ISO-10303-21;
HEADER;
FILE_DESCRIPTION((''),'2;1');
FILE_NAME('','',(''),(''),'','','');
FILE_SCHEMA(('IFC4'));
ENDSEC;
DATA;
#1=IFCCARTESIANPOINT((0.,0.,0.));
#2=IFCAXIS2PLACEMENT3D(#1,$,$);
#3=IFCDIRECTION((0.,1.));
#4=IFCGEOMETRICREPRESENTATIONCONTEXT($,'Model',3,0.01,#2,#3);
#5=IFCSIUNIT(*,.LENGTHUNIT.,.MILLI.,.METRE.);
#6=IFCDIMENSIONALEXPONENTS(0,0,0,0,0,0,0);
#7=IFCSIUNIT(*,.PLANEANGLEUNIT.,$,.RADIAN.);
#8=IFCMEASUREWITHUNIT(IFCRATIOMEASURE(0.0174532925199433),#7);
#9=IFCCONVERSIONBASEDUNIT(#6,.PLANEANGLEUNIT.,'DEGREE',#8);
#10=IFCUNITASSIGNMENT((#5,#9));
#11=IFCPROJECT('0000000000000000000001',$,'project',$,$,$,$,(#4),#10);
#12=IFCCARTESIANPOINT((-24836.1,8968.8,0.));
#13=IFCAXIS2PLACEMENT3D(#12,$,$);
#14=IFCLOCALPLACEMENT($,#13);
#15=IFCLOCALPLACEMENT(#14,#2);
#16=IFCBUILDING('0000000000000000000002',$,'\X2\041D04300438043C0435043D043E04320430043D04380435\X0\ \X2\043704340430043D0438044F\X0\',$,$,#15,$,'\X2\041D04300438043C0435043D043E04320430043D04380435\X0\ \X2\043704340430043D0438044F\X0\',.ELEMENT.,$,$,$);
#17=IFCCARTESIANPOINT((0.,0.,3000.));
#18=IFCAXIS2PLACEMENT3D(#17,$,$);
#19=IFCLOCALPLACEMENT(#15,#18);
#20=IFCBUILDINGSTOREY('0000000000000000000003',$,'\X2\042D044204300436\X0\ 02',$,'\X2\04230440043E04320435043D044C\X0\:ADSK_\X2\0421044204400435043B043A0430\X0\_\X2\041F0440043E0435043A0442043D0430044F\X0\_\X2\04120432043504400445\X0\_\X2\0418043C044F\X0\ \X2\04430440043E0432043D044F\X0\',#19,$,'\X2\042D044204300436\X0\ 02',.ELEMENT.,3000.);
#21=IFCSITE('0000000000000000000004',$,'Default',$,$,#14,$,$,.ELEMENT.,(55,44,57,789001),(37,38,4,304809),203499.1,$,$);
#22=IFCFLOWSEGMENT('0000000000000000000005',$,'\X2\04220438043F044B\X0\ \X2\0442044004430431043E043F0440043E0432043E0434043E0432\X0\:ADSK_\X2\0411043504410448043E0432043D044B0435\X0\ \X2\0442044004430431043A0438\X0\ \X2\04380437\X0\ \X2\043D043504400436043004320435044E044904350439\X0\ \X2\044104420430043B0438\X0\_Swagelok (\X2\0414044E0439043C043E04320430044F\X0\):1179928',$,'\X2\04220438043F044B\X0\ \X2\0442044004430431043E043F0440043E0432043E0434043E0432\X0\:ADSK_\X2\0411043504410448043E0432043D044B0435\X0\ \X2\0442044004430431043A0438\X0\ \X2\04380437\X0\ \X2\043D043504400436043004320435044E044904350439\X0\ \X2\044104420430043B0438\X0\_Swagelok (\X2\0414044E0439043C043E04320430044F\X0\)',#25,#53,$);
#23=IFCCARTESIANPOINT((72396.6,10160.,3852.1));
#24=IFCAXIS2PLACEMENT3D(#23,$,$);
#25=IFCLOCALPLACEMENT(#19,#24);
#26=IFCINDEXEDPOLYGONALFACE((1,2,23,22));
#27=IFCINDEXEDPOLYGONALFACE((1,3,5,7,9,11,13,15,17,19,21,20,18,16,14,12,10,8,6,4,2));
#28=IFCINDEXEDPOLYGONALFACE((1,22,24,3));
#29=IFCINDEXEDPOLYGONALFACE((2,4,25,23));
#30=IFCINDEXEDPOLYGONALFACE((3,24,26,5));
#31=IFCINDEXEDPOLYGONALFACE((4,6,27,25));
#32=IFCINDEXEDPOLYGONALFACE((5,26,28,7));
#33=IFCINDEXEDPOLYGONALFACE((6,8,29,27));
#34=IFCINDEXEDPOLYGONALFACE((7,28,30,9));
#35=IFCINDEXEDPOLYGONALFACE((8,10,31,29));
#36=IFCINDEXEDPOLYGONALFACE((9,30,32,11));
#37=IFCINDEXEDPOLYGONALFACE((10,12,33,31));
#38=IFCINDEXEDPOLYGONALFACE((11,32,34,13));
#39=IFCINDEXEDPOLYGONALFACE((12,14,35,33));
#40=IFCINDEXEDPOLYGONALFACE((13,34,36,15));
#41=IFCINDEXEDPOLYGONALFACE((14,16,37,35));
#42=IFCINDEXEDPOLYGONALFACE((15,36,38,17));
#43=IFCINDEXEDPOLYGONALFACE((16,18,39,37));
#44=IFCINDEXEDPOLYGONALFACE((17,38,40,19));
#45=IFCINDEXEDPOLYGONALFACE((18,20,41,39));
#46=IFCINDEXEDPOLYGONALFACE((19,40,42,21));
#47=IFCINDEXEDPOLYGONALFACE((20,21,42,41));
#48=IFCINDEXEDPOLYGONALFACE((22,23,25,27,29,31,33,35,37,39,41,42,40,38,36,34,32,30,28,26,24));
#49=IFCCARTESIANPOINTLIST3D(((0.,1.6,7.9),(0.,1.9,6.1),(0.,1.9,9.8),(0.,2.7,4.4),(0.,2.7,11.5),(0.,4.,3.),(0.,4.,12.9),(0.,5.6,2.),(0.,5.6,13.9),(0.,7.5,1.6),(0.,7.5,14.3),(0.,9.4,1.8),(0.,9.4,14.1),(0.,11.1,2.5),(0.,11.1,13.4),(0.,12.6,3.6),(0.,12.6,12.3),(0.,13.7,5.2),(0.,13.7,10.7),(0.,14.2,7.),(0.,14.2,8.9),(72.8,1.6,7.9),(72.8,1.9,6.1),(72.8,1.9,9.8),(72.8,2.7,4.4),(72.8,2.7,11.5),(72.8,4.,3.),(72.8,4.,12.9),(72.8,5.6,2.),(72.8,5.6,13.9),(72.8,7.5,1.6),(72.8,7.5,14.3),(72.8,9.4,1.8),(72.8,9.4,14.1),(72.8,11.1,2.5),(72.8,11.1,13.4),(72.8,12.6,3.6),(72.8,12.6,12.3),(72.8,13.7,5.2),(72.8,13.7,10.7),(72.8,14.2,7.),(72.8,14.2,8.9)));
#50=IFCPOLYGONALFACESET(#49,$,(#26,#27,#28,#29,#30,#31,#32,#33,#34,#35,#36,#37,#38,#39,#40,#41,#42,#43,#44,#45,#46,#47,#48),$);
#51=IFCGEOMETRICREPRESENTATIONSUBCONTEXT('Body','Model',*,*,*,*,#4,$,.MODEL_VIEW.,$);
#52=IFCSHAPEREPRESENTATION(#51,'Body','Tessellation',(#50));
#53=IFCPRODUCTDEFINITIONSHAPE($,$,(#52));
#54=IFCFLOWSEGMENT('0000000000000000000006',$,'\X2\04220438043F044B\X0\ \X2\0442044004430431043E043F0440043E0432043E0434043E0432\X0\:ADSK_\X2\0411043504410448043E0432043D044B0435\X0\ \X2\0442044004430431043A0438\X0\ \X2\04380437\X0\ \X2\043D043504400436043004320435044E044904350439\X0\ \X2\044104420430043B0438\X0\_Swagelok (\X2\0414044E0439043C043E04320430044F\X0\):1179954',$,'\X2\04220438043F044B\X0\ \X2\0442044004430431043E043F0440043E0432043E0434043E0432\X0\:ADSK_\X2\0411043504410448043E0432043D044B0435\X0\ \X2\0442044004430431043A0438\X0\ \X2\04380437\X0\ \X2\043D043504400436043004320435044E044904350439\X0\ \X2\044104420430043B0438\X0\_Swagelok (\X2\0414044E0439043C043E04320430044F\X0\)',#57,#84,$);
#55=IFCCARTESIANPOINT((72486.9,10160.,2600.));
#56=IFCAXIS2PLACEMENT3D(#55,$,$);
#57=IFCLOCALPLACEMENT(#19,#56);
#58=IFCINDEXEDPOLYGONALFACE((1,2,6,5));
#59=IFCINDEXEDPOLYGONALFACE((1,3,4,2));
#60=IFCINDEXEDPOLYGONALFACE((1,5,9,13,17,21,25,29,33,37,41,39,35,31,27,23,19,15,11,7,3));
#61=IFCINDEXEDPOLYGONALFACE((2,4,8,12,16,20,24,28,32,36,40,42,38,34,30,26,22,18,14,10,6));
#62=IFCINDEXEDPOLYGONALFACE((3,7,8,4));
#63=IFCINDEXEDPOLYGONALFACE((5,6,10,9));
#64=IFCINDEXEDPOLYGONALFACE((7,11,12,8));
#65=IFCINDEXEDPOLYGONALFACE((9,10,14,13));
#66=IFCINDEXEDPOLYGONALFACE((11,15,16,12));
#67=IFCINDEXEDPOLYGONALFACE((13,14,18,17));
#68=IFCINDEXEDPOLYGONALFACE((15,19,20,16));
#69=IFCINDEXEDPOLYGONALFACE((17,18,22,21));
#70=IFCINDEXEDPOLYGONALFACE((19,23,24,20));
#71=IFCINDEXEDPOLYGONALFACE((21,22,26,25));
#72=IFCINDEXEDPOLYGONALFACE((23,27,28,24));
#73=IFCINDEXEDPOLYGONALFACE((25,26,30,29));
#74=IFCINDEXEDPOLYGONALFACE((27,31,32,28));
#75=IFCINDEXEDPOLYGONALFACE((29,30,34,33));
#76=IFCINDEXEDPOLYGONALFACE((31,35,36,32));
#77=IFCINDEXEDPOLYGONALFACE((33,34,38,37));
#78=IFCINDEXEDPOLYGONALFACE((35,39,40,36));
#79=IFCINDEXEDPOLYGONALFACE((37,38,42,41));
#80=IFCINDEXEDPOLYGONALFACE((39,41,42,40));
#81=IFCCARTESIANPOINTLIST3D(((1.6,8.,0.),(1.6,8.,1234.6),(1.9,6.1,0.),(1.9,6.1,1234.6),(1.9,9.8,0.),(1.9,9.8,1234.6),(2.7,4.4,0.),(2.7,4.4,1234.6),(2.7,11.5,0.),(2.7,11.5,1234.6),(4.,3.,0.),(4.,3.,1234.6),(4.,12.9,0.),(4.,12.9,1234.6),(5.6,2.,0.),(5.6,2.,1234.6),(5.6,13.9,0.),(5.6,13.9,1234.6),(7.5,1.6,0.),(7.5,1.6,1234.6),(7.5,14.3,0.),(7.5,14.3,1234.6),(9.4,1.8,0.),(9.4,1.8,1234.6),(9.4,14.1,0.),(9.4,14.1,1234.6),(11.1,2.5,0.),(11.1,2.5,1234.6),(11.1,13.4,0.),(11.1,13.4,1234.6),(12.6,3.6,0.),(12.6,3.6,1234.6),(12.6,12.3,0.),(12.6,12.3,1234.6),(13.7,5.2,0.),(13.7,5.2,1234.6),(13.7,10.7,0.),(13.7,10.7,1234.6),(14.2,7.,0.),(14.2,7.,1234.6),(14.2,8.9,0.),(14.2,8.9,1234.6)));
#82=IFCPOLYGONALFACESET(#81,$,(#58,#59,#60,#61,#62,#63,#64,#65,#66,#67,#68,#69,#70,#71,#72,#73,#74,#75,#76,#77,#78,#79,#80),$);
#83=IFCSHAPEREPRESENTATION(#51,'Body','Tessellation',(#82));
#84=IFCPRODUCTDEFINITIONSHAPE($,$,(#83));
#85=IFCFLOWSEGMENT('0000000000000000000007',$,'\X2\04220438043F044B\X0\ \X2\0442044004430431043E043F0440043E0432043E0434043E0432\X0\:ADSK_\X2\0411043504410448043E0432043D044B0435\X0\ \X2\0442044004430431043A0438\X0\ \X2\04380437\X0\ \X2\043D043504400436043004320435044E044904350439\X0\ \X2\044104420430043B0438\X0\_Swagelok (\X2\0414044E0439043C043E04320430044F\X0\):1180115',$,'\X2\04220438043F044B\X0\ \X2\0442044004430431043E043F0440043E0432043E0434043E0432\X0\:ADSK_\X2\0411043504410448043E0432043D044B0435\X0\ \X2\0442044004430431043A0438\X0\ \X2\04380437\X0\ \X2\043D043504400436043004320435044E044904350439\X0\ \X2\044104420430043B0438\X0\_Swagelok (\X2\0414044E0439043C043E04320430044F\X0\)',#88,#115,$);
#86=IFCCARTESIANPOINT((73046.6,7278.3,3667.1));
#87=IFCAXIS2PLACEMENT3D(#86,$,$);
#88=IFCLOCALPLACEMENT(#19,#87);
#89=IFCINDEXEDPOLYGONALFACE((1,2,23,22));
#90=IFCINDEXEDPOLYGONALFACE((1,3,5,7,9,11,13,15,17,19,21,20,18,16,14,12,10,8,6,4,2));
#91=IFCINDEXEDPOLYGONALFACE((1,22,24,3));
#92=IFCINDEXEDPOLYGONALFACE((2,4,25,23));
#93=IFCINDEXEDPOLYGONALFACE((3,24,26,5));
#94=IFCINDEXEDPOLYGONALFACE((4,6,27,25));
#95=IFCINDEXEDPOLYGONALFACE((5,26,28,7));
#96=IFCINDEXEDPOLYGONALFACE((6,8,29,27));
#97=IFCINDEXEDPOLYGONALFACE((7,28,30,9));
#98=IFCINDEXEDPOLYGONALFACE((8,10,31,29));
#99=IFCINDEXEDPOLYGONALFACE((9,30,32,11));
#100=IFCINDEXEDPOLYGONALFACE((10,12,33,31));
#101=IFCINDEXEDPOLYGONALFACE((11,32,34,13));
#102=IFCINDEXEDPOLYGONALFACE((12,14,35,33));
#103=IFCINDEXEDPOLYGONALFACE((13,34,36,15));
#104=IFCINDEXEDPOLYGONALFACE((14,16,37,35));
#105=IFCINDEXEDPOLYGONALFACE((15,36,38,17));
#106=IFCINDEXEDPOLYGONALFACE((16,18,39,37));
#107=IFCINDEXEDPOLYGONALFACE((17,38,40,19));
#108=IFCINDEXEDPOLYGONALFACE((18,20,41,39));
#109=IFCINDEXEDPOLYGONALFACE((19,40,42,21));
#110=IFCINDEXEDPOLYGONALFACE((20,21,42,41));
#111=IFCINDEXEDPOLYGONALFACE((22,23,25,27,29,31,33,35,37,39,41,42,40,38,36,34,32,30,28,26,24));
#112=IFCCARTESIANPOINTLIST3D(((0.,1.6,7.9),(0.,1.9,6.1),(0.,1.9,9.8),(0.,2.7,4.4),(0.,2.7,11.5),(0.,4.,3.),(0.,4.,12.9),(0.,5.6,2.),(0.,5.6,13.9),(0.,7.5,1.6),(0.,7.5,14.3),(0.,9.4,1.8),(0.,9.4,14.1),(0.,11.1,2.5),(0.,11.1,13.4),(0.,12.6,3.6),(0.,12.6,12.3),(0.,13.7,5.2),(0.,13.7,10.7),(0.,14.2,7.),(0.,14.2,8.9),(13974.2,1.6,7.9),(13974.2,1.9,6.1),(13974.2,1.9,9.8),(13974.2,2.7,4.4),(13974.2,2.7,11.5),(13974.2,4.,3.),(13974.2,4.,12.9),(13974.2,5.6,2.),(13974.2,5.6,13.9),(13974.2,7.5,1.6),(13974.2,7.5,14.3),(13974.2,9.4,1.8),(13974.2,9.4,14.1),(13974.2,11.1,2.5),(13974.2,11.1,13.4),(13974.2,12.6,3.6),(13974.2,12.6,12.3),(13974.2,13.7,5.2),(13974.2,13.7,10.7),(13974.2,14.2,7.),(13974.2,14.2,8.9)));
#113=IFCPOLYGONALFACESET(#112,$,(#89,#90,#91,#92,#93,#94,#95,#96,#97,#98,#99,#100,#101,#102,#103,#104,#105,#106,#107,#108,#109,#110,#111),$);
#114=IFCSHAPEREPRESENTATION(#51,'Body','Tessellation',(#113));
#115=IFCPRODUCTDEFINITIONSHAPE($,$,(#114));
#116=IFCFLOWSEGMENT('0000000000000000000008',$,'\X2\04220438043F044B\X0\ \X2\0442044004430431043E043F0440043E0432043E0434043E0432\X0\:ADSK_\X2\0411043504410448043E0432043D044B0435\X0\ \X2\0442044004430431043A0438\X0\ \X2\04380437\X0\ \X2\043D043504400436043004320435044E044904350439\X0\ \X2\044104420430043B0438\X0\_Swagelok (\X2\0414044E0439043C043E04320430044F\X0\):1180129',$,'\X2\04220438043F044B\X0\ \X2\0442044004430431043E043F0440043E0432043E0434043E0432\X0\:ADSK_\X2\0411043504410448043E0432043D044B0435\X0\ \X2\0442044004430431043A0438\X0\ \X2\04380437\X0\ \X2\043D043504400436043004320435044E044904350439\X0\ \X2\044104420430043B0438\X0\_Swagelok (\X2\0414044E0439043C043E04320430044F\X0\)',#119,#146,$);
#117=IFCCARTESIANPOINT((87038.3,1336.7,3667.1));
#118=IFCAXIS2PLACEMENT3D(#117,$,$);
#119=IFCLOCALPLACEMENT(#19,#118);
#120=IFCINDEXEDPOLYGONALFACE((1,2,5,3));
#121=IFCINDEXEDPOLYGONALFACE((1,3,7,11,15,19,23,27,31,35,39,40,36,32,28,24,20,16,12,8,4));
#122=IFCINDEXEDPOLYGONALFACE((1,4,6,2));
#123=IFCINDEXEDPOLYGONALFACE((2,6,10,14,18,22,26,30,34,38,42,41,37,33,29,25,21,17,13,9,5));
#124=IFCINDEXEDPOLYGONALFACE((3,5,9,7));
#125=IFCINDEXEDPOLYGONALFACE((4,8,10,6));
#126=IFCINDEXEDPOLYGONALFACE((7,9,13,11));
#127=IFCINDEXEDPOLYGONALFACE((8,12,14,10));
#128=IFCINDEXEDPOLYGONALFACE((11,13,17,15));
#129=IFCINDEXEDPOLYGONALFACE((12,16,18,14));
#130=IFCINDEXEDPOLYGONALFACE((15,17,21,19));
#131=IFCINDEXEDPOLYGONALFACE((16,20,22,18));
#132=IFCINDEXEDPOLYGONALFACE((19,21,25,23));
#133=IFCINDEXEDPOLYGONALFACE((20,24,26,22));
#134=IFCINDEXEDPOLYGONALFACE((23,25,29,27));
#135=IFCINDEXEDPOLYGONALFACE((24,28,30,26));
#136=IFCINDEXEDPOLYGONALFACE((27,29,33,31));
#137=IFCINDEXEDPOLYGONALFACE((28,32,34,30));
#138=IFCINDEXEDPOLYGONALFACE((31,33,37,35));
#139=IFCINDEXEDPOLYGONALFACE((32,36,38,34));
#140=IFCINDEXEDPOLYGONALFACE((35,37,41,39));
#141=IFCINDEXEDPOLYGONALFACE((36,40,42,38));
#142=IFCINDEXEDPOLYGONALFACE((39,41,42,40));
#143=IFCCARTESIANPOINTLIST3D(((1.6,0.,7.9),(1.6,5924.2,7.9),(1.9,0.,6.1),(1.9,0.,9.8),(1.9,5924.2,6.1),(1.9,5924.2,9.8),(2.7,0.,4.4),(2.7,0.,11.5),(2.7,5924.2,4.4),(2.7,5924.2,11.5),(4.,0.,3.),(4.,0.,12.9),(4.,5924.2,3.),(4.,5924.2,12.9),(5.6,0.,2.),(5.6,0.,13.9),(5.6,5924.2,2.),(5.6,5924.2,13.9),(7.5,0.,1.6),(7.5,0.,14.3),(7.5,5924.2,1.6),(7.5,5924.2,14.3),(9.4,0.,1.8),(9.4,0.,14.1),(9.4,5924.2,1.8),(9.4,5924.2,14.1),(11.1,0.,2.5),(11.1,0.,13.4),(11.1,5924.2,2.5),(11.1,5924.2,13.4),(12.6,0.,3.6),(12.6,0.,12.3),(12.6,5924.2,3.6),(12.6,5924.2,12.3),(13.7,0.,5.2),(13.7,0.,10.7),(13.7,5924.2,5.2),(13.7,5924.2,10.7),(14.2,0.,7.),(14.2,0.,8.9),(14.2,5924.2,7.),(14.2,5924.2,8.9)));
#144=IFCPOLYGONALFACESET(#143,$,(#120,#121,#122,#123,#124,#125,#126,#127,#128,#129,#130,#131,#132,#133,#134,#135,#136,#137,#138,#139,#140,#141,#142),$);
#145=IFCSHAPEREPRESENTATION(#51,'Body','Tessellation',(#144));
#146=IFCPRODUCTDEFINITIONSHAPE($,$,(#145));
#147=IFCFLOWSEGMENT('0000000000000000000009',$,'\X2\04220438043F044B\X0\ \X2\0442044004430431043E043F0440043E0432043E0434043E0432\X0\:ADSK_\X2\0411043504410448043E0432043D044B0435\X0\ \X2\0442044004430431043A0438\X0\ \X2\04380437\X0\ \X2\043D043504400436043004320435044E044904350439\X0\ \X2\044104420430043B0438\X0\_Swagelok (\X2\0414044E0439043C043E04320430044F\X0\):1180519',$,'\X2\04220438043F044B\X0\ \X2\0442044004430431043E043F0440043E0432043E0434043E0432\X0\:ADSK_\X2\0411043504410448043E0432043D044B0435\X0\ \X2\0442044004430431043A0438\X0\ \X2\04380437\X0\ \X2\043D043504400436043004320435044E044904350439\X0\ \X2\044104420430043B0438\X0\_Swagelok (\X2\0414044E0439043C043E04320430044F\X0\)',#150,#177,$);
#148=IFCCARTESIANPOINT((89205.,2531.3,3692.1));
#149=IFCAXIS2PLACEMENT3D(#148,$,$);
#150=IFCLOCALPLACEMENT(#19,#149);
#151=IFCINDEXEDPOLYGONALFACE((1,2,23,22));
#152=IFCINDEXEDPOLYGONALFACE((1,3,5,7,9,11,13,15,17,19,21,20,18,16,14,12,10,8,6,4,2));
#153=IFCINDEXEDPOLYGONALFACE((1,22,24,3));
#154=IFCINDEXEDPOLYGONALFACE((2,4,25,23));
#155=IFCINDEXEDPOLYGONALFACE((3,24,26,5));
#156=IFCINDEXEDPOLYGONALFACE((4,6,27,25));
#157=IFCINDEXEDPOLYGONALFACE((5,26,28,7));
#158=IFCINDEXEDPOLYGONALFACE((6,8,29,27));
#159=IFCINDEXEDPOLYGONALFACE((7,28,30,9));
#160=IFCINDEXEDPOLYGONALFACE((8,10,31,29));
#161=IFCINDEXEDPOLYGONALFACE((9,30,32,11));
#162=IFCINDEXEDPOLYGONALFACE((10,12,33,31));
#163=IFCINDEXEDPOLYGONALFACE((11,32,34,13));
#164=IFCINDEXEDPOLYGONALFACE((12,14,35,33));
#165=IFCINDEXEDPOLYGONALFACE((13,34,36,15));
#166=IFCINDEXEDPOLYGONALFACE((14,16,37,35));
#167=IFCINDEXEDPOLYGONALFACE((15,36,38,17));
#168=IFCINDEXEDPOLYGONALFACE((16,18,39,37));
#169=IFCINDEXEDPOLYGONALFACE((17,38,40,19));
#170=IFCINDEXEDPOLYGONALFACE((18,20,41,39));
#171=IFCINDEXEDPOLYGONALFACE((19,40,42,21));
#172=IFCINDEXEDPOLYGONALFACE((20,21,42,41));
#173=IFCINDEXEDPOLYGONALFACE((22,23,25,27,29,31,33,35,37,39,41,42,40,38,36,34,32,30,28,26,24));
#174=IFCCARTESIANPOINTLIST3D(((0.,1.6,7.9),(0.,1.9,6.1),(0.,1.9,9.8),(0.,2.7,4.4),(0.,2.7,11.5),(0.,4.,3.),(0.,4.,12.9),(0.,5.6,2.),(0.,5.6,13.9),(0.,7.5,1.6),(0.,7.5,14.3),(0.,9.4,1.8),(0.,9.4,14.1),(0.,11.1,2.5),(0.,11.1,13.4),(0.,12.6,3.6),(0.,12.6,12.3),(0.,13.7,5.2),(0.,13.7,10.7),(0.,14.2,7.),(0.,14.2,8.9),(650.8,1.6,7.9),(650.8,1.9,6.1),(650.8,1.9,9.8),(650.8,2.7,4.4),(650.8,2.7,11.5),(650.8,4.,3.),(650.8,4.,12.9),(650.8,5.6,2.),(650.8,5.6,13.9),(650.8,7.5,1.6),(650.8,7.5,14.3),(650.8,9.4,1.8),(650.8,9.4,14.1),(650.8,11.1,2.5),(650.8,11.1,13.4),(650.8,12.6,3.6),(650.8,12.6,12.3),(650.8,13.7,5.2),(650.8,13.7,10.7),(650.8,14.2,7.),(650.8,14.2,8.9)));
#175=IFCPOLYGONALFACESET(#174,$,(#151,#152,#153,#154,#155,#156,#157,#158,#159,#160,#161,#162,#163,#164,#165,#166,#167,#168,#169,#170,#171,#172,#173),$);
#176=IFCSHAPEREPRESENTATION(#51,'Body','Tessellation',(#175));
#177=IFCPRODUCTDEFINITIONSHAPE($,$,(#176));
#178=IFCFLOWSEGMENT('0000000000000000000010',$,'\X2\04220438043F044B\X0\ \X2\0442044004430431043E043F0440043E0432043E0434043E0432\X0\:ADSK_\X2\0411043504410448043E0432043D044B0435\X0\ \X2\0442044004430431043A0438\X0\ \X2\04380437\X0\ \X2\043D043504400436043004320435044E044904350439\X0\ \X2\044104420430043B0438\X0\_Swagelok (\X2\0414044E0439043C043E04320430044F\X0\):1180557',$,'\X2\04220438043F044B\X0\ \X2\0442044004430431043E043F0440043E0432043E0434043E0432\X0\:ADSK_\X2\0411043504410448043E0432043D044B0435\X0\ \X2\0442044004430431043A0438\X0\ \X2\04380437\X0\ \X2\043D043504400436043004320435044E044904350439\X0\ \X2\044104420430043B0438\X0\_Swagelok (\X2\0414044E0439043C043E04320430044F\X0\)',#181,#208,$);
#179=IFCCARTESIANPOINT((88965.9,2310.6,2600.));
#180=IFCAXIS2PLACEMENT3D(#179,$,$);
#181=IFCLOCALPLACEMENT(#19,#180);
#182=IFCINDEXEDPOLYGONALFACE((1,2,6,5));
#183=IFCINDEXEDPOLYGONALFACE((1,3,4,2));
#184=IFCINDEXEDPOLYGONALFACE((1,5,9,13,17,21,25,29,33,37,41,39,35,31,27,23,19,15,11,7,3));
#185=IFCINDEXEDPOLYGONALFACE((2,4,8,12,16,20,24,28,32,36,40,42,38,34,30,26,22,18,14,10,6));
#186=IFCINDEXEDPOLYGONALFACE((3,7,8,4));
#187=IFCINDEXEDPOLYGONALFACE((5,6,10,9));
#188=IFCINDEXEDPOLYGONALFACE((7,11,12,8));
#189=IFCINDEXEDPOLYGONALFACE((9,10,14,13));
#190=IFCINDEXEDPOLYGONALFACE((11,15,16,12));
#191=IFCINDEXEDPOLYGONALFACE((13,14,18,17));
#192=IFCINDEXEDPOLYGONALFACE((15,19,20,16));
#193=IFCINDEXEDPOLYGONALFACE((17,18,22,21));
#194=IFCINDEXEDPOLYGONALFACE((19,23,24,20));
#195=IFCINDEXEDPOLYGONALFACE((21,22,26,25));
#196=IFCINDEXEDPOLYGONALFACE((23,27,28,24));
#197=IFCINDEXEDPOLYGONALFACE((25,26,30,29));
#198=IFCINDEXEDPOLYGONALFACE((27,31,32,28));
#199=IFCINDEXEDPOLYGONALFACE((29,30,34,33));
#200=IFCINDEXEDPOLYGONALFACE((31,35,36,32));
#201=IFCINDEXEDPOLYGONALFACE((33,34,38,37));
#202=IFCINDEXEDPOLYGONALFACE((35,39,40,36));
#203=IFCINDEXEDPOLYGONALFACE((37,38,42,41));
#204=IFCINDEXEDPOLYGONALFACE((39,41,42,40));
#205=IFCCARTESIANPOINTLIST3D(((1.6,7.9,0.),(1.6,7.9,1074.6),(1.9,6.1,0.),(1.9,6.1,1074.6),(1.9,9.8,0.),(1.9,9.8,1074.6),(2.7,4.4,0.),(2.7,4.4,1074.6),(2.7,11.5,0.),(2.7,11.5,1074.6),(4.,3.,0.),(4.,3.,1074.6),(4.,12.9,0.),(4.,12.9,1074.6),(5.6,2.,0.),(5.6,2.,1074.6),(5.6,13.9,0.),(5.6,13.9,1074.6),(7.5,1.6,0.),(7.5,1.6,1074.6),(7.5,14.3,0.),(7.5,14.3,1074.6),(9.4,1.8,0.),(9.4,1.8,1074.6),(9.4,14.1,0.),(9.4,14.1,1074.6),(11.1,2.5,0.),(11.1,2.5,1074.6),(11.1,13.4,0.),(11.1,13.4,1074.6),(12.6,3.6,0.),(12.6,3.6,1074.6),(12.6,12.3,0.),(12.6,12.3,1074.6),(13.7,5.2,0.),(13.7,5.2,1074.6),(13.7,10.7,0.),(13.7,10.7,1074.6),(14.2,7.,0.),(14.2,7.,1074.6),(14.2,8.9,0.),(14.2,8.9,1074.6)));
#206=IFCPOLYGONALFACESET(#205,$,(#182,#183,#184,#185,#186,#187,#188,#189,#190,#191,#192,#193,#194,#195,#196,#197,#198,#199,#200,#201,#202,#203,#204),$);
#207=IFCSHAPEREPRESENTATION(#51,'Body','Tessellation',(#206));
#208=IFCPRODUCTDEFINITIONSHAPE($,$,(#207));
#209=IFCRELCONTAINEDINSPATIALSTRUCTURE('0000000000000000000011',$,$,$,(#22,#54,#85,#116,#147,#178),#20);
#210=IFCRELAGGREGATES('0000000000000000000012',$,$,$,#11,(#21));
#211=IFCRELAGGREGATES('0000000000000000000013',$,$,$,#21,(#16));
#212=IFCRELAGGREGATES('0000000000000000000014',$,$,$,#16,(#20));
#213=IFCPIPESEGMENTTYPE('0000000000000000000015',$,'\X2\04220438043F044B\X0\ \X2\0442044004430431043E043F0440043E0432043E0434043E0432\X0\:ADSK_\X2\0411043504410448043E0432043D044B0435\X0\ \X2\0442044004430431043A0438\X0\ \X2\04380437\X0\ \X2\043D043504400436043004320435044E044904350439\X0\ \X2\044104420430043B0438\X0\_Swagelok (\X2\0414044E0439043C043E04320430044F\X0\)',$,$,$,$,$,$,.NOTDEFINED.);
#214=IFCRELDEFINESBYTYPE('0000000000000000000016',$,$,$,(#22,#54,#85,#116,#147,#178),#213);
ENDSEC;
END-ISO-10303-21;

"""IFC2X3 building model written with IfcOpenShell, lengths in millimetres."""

from ifc_helpers import new_model, entity, si_unit, converted_unit, direction, frame, origin, origin_2d_with_axis, place, context, subcontext, project, spatial, circle, extrude, type_object, element, save


model = new_model("IFC2X3")

# Units and contexts
model_context = context("Model", 3, precision=0.01, world=origin(), true_north=direction((0.0, 1.0)))
body_context = subcontext(model_context, "Body", "Model", "MODEL_VIEW")
ifc_project = project(units=[si_unit("LENGTHUNIT", "METRE", prefix="MILLI"), converted_unit("PLANEANGLEUNIT", "DEGREE", entity("IfcRatioMeasure", 0.0174532925199433), si_unit("PLANEANGLEUNIT", "RADIAN"), dimensions=[0, 0, 0, 0, 0, 0, 0])], contexts=[model_context])

# Site, building, storey
site_placement = place(None, frame((-24836.1, 8968.8, 0.0)))
site = spatial("IfcSite", under=ifc_project, at=site_placement, Name="Default", CompositionType="ELEMENT", RefLatitude=(55, 44, 57, 789001), RefLongitude=(37, 38, 4, 304809), RefElevation=203499.1)
building_placement = place(site_placement, origin())
building = spatial("IfcBuilding", under=site, at=building_placement, Name="Наименование здания", LongName="Наименование здания", CompositionType="ELEMENT")
storey_placement = place(building_placement, frame((0.0, 0.0, 3000.0)))
storey = spatial("IfcBuildingStorey", under=building, at=storey_placement, Name="Этаж 02", ObjectType="Уровень:ADSK_Стрелка_Проектная_Вверх_Имя уровня", LongName="Этаж 02", CompositionType="ELEMENT", Elevation=3000.0)

# Flow segments
pipe_segment_type_1 = type_object("IfcPipeSegmentType", Name="Типы трубопроводов:ADSK_Бесшовные трубки из нержавеющей стали_Swagelok (Дюймовая)", PredefinedType="NOTDEFINED")
flow_segment_1_placement = place(storey_placement, frame((72396.6, 10160.0, 3852.1)))
element("IfcFlowSegment", 1, at=flow_segment_1_placement, inside=storey, type_object=pipe_segment_type_1, Name="Типы трубопроводов:ADSK_Бесшовные трубки из нержавеющей стали_Swagelok (Дюймовая):1179928", ObjectType="Типы трубопроводов:ADSK_Бесшовные трубки из нержавеющей стали_Swagelok (Дюймовая)", context=body_context, shape_type="SweptSolid", body=[
    extrude(circle(Radius=6.3, at=origin_2d_with_axis()), frame((0.0, 8.0, 8.0), z_axis=(1.0, 0.0, 0.0), x_axis=(0.0, -1.0, 0.0)), (0.0, 0.0, 1.0), 72.8),
])
flow_segment_2_placement = place(storey_placement, frame((72486.9, 10160.0, 2600.0)))
element("IfcFlowSegment", 2, at=flow_segment_2_placement, inside=storey, type_object=pipe_segment_type_1, Name="Типы трубопроводов:ADSK_Бесшовные трубки из нержавеющей стали_Swagelok (Дюймовая):1179954", ObjectType="Типы трубопроводов:ADSK_Бесшовные трубки из нержавеющей стали_Swagelok (Дюймовая)", context=body_context, shape_type="SweptSolid", body=[
    extrude(circle(Radius=6.3, at=origin_2d_with_axis()), frame((8.0, 8.0, 0.0), z_axis=(0.0, 0.0, 1.0), x_axis=(-1.0, 0.0, 0.0)), (0.0, 0.0, 1.0), 1234.6),
])
flow_segment_3_placement = place(storey_placement, frame((73046.6, 7278.3, 3667.1)))
element("IfcFlowSegment", 3, at=flow_segment_3_placement, inside=storey, type_object=pipe_segment_type_1, Name="Типы трубопроводов:ADSK_Бесшовные трубки из нержавеющей стали_Swagelok (Дюймовая):1180115", ObjectType="Типы трубопроводов:ADSK_Бесшовные трубки из нержавеющей стали_Swagelok (Дюймовая)", context=body_context, shape_type="SweptSolid", body=[
    extrude(circle(Radius=6.3, at=origin_2d_with_axis()), frame((0.0, 8.0, 8.0), z_axis=(1.0, 0.0, 0.0), x_axis=(0.0, -1.0, 0.0)), (0.0, 0.0, 1.0), 13974.2),
])
flow_segment_4_placement = place(storey_placement, frame((87038.3, 1336.7, 3667.1)))
element("IfcFlowSegment", 4, at=flow_segment_4_placement, inside=storey, type_object=pipe_segment_type_1, Name="Типы трубопроводов:ADSK_Бесшовные трубки из нержавеющей стали_Swagelok (Дюймовая):1180129", ObjectType="Типы трубопроводов:ADSK_Бесшовные трубки из нержавеющей стали_Swagelok (Дюймовая)", context=body_context, shape_type="SweptSolid", body=[
    extrude(circle(Radius=6.3, at=origin_2d_with_axis()), frame((8.0, 0.0, 8.0), z_axis=(0.0, 1.0, 0.0), x_axis=(-1.0, 0.0, 0.0)), (0.0, 0.0, 1.0), 5924.2),
])
flow_segment_5_placement = place(storey_placement, frame((89205.0, 2531.3, 3692.1)))
element("IfcFlowSegment", 5, at=flow_segment_5_placement, inside=storey, type_object=pipe_segment_type_1, Name="Типы трубопроводов:ADSK_Бесшовные трубки из нержавеющей стали_Swagelok (Дюймовая):1180519", ObjectType="Типы трубопроводов:ADSK_Бесшовные трубки из нержавеющей стали_Swagelok (Дюймовая)", context=body_context, shape_type="SweptSolid", body=[
    extrude(circle(Radius=6.3, at=origin_2d_with_axis()), frame((0.0, 8.0, 8.0), z_axis=(1.0, 0.0, 0.0), x_axis=(0.0, -1.0, 0.0)), (0.0, 0.0, 1.0), 650.8),
])
flow_segment_6_placement = place(storey_placement, frame((88965.9, 2310.6, 2600.0)))
element("IfcFlowSegment", 6, at=flow_segment_6_placement, inside=storey, type_object=pipe_segment_type_1, Name="Типы трубопроводов:ADSK_Бесшовные трубки из нержавеющей стали_Swagelok (Дюймовая):1180557", ObjectType="Типы трубопроводов:ADSK_Бесшовные трубки из нержавеющей стали_Swagelok (Дюймовая)", context=body_context, shape_type="SweptSolid", body=[
    extrude(circle(Radius=6.3, at=origin_2d_with_axis()), frame((8.0, 8.0, 0.0), z_axis=(0.0, 0.0, 1.0), x_axis=(-1.0, 0.0, 0.0)), (0.0, 0.0, 1.0), 1074.6),
])

save(model, "model.ifc")
